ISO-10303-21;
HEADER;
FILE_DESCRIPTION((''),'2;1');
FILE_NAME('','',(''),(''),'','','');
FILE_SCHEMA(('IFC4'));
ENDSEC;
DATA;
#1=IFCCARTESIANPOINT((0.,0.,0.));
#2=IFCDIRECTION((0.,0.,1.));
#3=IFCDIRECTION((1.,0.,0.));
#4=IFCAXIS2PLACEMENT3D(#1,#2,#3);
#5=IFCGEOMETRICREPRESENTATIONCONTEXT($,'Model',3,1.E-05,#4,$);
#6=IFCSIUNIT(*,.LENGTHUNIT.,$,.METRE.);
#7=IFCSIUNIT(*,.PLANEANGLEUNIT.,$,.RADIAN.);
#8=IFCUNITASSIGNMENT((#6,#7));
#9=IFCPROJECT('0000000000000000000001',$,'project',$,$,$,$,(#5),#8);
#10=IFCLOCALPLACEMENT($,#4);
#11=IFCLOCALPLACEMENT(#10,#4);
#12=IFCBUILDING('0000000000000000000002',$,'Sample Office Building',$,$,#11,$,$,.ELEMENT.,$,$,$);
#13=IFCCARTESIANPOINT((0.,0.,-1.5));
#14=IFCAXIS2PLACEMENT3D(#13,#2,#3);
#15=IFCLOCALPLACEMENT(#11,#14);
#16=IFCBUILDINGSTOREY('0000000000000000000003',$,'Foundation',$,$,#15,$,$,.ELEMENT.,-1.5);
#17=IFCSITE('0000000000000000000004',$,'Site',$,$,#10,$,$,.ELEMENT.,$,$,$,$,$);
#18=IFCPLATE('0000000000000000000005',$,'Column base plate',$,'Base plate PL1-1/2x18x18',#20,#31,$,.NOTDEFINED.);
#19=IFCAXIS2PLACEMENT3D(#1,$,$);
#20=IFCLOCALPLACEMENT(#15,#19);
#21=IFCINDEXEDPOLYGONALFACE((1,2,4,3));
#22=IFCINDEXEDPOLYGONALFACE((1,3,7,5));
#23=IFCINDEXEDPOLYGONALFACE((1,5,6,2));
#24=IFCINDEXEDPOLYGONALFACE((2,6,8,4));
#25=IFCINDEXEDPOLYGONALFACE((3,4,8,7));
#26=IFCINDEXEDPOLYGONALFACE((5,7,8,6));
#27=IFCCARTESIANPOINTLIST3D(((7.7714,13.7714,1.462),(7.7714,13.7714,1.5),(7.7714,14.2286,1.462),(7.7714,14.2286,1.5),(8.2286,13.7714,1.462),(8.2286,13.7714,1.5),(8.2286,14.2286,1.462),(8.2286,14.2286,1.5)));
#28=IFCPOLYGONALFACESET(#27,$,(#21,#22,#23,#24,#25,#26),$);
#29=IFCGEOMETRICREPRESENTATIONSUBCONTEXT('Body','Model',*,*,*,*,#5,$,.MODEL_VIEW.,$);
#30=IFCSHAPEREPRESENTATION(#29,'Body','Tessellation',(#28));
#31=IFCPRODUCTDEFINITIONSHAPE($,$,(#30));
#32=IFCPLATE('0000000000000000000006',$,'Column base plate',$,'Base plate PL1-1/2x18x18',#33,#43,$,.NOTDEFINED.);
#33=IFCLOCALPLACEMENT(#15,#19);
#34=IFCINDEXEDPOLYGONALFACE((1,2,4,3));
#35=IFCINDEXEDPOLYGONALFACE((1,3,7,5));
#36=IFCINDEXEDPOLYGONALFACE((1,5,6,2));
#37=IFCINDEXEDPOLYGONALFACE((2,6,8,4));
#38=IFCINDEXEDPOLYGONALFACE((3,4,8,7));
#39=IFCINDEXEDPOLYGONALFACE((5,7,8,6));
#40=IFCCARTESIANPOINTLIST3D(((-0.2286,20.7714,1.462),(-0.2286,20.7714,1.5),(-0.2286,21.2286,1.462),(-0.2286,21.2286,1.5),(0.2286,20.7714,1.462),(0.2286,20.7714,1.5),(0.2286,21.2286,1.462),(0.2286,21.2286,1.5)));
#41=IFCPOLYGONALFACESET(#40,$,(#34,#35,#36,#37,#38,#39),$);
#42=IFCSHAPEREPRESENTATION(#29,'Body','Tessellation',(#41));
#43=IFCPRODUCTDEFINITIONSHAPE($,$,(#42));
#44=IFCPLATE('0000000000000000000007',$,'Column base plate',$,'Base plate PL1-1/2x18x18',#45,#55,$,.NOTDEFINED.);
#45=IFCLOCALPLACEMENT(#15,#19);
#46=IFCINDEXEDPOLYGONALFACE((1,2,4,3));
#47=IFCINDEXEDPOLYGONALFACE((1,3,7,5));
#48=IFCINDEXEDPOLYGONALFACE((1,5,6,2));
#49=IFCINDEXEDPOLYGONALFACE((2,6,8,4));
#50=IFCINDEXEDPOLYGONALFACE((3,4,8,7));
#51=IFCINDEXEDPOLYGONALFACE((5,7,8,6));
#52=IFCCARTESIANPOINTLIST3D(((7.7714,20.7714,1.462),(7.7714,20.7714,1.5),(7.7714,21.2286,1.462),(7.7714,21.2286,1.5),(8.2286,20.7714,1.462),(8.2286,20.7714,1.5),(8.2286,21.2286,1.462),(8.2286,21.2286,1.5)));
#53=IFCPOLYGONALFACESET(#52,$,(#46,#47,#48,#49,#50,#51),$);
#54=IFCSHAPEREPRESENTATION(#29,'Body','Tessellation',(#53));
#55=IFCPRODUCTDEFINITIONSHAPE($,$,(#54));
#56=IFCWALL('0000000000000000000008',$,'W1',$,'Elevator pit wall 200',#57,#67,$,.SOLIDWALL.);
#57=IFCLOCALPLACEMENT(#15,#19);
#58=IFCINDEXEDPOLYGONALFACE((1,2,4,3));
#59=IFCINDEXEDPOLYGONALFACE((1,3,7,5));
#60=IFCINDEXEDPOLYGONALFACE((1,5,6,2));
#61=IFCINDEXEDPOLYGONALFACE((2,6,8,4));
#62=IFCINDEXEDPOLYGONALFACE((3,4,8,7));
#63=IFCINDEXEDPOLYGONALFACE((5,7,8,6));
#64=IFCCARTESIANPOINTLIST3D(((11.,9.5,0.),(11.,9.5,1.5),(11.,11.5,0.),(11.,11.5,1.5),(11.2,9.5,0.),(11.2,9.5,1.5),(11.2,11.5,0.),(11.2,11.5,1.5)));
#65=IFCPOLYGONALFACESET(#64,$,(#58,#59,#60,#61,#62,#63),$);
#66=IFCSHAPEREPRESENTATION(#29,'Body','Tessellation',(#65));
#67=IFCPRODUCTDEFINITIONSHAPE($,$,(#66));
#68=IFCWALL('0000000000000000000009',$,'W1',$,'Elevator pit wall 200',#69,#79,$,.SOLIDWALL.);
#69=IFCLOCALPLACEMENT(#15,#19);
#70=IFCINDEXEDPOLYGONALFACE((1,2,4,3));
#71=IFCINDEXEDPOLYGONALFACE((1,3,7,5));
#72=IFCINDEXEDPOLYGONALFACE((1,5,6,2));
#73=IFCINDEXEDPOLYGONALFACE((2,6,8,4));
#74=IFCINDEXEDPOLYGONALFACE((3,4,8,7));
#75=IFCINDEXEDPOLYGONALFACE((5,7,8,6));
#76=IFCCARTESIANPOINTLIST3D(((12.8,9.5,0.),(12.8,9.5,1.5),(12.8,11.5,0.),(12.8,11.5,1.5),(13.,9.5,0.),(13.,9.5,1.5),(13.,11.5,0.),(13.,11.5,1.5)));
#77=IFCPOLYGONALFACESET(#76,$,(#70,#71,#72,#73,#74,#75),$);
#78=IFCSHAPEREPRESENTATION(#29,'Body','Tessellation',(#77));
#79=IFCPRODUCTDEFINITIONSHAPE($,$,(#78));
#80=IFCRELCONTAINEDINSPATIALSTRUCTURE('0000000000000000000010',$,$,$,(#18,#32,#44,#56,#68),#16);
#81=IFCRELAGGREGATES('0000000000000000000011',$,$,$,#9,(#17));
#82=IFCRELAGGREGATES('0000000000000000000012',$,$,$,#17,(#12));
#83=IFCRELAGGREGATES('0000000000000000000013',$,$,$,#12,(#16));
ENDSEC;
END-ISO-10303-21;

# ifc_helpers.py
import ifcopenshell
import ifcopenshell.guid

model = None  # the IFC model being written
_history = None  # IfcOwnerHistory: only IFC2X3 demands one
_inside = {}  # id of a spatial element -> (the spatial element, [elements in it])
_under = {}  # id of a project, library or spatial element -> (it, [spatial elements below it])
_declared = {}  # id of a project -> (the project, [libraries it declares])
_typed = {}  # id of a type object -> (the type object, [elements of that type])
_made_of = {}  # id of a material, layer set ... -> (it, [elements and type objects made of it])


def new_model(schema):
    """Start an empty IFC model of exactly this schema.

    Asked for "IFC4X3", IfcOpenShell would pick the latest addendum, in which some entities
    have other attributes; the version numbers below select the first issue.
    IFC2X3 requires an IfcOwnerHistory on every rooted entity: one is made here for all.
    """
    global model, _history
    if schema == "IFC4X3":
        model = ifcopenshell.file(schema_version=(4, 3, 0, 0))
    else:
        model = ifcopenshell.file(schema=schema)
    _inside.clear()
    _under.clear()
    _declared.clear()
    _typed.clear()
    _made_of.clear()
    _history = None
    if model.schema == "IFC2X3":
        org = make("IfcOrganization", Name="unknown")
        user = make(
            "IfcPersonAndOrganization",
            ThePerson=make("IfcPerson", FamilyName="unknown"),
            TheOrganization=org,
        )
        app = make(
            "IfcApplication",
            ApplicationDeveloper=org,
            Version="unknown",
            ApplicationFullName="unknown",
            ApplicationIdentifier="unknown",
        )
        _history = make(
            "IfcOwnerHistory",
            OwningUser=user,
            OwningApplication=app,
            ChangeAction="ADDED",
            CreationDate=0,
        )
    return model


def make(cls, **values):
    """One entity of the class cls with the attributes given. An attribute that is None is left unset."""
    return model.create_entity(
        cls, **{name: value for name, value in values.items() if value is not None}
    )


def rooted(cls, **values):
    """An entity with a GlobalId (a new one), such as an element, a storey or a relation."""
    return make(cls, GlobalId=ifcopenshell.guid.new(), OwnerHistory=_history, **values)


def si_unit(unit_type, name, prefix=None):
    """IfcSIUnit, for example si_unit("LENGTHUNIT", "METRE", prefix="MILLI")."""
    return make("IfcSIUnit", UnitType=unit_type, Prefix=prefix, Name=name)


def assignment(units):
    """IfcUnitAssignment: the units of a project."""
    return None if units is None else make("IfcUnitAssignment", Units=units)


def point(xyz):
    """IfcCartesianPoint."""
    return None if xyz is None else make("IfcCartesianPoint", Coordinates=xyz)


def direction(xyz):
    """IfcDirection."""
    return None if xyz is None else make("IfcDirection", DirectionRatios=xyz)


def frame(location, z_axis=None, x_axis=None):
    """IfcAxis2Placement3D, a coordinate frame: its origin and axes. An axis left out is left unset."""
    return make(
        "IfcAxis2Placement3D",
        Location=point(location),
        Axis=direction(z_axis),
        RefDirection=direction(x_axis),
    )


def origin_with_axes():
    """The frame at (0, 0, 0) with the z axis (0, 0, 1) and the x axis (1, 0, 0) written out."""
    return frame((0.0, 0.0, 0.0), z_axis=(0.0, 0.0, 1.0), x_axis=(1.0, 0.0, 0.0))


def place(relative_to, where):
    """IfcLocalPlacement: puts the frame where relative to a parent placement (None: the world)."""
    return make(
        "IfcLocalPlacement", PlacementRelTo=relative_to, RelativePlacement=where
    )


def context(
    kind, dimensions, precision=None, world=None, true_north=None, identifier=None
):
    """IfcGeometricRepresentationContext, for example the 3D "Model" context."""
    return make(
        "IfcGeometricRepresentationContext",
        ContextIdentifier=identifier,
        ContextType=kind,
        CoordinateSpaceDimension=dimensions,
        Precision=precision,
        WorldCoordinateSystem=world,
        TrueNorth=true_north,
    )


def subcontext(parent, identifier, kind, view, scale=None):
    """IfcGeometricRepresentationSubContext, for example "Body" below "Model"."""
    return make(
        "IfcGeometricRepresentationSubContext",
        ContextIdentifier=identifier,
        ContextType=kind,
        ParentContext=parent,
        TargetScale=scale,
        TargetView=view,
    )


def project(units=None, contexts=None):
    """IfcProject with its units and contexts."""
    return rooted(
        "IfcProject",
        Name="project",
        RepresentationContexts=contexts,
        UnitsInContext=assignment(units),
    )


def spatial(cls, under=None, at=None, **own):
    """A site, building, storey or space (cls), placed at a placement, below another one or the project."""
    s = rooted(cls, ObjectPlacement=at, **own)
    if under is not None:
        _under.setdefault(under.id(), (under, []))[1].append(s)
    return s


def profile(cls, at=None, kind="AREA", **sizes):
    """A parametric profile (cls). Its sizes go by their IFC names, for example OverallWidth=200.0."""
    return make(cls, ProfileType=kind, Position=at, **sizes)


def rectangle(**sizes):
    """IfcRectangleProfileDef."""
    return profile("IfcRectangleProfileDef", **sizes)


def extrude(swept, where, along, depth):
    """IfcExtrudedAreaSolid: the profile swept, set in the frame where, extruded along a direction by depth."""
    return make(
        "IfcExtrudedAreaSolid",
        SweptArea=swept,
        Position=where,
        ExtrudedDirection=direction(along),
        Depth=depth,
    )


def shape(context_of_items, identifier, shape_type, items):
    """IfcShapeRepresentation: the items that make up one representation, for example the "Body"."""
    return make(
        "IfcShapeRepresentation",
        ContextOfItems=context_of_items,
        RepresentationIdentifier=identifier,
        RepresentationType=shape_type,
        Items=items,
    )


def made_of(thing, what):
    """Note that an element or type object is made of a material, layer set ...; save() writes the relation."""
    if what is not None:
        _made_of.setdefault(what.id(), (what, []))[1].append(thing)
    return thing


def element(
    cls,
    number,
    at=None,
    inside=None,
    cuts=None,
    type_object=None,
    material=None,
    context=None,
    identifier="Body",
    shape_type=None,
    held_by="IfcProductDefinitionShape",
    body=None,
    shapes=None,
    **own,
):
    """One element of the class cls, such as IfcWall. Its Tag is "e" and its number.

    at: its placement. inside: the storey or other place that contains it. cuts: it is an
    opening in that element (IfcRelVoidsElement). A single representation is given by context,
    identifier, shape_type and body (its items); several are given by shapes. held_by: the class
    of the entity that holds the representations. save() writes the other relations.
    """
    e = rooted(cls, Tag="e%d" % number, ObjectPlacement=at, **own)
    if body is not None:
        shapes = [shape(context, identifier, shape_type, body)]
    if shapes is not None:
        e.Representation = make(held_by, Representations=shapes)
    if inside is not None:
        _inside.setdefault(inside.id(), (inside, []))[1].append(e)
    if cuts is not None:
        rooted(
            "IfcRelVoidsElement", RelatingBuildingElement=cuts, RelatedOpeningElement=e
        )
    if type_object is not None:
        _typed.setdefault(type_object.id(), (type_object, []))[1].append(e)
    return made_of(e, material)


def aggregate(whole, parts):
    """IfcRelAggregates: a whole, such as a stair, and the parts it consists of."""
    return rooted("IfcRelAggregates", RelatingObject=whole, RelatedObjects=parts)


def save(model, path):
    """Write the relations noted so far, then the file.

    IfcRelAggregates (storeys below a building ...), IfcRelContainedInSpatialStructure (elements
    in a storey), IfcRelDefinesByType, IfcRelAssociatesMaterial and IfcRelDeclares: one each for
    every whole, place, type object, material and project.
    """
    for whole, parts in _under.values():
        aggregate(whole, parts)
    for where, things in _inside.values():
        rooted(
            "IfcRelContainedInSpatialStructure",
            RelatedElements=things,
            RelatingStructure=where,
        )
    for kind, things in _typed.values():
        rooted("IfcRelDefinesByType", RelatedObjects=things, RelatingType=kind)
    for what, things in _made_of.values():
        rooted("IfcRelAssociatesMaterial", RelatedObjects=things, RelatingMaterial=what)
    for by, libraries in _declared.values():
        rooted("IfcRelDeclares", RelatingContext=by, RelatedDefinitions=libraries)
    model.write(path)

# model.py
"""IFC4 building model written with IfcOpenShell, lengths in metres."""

from ifc_helpers import new_model, si_unit, frame, origin_with_axes, place, context, subcontext, project, spatial, rectangle, extrude, element, save


model = new_model("IFC4")

# Units and contexts
model_context = context("Model", 3, precision=1e-05, world=origin_with_axes())
body_context = subcontext(model_context, "Body", "Model", "MODEL_VIEW")
ifc_project = project(units=[si_unit("LENGTHUNIT", "METRE"), si_unit("PLANEANGLEUNIT", "RADIAN")], contexts=[model_context])

# Site, building, storey
site_placement = place(None, origin_with_axes())
site = spatial("IfcSite", under=ifc_project, at=site_placement, Name="Site", CompositionType="ELEMENT")
building_placement = place(site_placement, origin_with_axes())
building = spatial("IfcBuilding", under=site, at=building_placement, Name="Sample Office Building", CompositionType="ELEMENT")
storey_placement = place(building_placement, frame((0.0, 0.0, -1.5), z_axis=(0.0, 0.0, 1.0), x_axis=(1.0, 0.0, 0.0)))
storey = spatial("IfcBuildingStorey", under=building, at=storey_placement, Name="Foundation", CompositionType="ELEMENT", Elevation=-1.5)

# Plates
plate_1_placement = place(None, frame((8.0, 14.0, -0.038), z_axis=(0.0, 0.0, 1.0), x_axis=(1.0, 0.0, 0.0)))
element("IfcPlate", 1, at=plate_1_placement, inside=storey, Name="Column base plate", ObjectType="Base plate PL1-1/2x18x18", PredefinedType="NOTDEFINED", context=body_context, shape_type="SweptSolid", body=[
    extrude(rectangle(XDim=0.4572, YDim=0.4572), None, (0.0, 0.0, 1.0), 0.038),
])
plate_2_placement = place(None, frame((0.0, 21.0, -0.038), z_axis=(0.0, 0.0, 1.0), x_axis=(1.0, 0.0, 0.0)))
element("IfcPlate", 2, at=plate_2_placement, inside=storey, Name="Column base plate", ObjectType="Base plate PL1-1/2x18x18", PredefinedType="NOTDEFINED", context=body_context, shape_type="SweptSolid", body=[
    extrude(rectangle(XDim=0.4572, YDim=0.4572), None, (0.0, 0.0, 1.0), 0.038),
])
plate_3_placement = place(None, frame((8.0, 21.0, -0.038), z_axis=(0.0, 0.0, 1.0), x_axis=(1.0, 0.0, 0.0)))
element("IfcPlate", 3, at=plate_3_placement, inside=storey, Name="Column base plate", ObjectType="Base plate PL1-1/2x18x18", PredefinedType="NOTDEFINED", context=body_context, shape_type="SweptSolid", body=[
    extrude(rectangle(XDim=0.4572, YDim=0.4572), None, (0.0, 0.0, 1.0), 0.038),
])

# Walls
for number, where, z_axis, x_axis, name in (
    (4, (11.1, 10.5, -1.5), (0.0, 0.0, 1.0), (1.0, 0.0, 0.0), "W1"),
    (5, (12.9, 10.5, -1.5), (0.0, 0.0, 1.0), (1.0, 0.0, 0.0), "W1"),
):
    element("IfcWall", number, at=place(None, frame(where, z_axis=z_axis, x_axis=x_axis)), inside=storey, Name=name, ObjectType="Elevator pit wall 200", PredefinedType="SOLIDWALL", context=body_context, shape_type="SweptSolid", body=[
        extrude(rectangle(XDim=0.2, YDim=2.0), None, (0.0, 0.0, 1.0), 1.5),
    ])

save(model, "model.ifc")
